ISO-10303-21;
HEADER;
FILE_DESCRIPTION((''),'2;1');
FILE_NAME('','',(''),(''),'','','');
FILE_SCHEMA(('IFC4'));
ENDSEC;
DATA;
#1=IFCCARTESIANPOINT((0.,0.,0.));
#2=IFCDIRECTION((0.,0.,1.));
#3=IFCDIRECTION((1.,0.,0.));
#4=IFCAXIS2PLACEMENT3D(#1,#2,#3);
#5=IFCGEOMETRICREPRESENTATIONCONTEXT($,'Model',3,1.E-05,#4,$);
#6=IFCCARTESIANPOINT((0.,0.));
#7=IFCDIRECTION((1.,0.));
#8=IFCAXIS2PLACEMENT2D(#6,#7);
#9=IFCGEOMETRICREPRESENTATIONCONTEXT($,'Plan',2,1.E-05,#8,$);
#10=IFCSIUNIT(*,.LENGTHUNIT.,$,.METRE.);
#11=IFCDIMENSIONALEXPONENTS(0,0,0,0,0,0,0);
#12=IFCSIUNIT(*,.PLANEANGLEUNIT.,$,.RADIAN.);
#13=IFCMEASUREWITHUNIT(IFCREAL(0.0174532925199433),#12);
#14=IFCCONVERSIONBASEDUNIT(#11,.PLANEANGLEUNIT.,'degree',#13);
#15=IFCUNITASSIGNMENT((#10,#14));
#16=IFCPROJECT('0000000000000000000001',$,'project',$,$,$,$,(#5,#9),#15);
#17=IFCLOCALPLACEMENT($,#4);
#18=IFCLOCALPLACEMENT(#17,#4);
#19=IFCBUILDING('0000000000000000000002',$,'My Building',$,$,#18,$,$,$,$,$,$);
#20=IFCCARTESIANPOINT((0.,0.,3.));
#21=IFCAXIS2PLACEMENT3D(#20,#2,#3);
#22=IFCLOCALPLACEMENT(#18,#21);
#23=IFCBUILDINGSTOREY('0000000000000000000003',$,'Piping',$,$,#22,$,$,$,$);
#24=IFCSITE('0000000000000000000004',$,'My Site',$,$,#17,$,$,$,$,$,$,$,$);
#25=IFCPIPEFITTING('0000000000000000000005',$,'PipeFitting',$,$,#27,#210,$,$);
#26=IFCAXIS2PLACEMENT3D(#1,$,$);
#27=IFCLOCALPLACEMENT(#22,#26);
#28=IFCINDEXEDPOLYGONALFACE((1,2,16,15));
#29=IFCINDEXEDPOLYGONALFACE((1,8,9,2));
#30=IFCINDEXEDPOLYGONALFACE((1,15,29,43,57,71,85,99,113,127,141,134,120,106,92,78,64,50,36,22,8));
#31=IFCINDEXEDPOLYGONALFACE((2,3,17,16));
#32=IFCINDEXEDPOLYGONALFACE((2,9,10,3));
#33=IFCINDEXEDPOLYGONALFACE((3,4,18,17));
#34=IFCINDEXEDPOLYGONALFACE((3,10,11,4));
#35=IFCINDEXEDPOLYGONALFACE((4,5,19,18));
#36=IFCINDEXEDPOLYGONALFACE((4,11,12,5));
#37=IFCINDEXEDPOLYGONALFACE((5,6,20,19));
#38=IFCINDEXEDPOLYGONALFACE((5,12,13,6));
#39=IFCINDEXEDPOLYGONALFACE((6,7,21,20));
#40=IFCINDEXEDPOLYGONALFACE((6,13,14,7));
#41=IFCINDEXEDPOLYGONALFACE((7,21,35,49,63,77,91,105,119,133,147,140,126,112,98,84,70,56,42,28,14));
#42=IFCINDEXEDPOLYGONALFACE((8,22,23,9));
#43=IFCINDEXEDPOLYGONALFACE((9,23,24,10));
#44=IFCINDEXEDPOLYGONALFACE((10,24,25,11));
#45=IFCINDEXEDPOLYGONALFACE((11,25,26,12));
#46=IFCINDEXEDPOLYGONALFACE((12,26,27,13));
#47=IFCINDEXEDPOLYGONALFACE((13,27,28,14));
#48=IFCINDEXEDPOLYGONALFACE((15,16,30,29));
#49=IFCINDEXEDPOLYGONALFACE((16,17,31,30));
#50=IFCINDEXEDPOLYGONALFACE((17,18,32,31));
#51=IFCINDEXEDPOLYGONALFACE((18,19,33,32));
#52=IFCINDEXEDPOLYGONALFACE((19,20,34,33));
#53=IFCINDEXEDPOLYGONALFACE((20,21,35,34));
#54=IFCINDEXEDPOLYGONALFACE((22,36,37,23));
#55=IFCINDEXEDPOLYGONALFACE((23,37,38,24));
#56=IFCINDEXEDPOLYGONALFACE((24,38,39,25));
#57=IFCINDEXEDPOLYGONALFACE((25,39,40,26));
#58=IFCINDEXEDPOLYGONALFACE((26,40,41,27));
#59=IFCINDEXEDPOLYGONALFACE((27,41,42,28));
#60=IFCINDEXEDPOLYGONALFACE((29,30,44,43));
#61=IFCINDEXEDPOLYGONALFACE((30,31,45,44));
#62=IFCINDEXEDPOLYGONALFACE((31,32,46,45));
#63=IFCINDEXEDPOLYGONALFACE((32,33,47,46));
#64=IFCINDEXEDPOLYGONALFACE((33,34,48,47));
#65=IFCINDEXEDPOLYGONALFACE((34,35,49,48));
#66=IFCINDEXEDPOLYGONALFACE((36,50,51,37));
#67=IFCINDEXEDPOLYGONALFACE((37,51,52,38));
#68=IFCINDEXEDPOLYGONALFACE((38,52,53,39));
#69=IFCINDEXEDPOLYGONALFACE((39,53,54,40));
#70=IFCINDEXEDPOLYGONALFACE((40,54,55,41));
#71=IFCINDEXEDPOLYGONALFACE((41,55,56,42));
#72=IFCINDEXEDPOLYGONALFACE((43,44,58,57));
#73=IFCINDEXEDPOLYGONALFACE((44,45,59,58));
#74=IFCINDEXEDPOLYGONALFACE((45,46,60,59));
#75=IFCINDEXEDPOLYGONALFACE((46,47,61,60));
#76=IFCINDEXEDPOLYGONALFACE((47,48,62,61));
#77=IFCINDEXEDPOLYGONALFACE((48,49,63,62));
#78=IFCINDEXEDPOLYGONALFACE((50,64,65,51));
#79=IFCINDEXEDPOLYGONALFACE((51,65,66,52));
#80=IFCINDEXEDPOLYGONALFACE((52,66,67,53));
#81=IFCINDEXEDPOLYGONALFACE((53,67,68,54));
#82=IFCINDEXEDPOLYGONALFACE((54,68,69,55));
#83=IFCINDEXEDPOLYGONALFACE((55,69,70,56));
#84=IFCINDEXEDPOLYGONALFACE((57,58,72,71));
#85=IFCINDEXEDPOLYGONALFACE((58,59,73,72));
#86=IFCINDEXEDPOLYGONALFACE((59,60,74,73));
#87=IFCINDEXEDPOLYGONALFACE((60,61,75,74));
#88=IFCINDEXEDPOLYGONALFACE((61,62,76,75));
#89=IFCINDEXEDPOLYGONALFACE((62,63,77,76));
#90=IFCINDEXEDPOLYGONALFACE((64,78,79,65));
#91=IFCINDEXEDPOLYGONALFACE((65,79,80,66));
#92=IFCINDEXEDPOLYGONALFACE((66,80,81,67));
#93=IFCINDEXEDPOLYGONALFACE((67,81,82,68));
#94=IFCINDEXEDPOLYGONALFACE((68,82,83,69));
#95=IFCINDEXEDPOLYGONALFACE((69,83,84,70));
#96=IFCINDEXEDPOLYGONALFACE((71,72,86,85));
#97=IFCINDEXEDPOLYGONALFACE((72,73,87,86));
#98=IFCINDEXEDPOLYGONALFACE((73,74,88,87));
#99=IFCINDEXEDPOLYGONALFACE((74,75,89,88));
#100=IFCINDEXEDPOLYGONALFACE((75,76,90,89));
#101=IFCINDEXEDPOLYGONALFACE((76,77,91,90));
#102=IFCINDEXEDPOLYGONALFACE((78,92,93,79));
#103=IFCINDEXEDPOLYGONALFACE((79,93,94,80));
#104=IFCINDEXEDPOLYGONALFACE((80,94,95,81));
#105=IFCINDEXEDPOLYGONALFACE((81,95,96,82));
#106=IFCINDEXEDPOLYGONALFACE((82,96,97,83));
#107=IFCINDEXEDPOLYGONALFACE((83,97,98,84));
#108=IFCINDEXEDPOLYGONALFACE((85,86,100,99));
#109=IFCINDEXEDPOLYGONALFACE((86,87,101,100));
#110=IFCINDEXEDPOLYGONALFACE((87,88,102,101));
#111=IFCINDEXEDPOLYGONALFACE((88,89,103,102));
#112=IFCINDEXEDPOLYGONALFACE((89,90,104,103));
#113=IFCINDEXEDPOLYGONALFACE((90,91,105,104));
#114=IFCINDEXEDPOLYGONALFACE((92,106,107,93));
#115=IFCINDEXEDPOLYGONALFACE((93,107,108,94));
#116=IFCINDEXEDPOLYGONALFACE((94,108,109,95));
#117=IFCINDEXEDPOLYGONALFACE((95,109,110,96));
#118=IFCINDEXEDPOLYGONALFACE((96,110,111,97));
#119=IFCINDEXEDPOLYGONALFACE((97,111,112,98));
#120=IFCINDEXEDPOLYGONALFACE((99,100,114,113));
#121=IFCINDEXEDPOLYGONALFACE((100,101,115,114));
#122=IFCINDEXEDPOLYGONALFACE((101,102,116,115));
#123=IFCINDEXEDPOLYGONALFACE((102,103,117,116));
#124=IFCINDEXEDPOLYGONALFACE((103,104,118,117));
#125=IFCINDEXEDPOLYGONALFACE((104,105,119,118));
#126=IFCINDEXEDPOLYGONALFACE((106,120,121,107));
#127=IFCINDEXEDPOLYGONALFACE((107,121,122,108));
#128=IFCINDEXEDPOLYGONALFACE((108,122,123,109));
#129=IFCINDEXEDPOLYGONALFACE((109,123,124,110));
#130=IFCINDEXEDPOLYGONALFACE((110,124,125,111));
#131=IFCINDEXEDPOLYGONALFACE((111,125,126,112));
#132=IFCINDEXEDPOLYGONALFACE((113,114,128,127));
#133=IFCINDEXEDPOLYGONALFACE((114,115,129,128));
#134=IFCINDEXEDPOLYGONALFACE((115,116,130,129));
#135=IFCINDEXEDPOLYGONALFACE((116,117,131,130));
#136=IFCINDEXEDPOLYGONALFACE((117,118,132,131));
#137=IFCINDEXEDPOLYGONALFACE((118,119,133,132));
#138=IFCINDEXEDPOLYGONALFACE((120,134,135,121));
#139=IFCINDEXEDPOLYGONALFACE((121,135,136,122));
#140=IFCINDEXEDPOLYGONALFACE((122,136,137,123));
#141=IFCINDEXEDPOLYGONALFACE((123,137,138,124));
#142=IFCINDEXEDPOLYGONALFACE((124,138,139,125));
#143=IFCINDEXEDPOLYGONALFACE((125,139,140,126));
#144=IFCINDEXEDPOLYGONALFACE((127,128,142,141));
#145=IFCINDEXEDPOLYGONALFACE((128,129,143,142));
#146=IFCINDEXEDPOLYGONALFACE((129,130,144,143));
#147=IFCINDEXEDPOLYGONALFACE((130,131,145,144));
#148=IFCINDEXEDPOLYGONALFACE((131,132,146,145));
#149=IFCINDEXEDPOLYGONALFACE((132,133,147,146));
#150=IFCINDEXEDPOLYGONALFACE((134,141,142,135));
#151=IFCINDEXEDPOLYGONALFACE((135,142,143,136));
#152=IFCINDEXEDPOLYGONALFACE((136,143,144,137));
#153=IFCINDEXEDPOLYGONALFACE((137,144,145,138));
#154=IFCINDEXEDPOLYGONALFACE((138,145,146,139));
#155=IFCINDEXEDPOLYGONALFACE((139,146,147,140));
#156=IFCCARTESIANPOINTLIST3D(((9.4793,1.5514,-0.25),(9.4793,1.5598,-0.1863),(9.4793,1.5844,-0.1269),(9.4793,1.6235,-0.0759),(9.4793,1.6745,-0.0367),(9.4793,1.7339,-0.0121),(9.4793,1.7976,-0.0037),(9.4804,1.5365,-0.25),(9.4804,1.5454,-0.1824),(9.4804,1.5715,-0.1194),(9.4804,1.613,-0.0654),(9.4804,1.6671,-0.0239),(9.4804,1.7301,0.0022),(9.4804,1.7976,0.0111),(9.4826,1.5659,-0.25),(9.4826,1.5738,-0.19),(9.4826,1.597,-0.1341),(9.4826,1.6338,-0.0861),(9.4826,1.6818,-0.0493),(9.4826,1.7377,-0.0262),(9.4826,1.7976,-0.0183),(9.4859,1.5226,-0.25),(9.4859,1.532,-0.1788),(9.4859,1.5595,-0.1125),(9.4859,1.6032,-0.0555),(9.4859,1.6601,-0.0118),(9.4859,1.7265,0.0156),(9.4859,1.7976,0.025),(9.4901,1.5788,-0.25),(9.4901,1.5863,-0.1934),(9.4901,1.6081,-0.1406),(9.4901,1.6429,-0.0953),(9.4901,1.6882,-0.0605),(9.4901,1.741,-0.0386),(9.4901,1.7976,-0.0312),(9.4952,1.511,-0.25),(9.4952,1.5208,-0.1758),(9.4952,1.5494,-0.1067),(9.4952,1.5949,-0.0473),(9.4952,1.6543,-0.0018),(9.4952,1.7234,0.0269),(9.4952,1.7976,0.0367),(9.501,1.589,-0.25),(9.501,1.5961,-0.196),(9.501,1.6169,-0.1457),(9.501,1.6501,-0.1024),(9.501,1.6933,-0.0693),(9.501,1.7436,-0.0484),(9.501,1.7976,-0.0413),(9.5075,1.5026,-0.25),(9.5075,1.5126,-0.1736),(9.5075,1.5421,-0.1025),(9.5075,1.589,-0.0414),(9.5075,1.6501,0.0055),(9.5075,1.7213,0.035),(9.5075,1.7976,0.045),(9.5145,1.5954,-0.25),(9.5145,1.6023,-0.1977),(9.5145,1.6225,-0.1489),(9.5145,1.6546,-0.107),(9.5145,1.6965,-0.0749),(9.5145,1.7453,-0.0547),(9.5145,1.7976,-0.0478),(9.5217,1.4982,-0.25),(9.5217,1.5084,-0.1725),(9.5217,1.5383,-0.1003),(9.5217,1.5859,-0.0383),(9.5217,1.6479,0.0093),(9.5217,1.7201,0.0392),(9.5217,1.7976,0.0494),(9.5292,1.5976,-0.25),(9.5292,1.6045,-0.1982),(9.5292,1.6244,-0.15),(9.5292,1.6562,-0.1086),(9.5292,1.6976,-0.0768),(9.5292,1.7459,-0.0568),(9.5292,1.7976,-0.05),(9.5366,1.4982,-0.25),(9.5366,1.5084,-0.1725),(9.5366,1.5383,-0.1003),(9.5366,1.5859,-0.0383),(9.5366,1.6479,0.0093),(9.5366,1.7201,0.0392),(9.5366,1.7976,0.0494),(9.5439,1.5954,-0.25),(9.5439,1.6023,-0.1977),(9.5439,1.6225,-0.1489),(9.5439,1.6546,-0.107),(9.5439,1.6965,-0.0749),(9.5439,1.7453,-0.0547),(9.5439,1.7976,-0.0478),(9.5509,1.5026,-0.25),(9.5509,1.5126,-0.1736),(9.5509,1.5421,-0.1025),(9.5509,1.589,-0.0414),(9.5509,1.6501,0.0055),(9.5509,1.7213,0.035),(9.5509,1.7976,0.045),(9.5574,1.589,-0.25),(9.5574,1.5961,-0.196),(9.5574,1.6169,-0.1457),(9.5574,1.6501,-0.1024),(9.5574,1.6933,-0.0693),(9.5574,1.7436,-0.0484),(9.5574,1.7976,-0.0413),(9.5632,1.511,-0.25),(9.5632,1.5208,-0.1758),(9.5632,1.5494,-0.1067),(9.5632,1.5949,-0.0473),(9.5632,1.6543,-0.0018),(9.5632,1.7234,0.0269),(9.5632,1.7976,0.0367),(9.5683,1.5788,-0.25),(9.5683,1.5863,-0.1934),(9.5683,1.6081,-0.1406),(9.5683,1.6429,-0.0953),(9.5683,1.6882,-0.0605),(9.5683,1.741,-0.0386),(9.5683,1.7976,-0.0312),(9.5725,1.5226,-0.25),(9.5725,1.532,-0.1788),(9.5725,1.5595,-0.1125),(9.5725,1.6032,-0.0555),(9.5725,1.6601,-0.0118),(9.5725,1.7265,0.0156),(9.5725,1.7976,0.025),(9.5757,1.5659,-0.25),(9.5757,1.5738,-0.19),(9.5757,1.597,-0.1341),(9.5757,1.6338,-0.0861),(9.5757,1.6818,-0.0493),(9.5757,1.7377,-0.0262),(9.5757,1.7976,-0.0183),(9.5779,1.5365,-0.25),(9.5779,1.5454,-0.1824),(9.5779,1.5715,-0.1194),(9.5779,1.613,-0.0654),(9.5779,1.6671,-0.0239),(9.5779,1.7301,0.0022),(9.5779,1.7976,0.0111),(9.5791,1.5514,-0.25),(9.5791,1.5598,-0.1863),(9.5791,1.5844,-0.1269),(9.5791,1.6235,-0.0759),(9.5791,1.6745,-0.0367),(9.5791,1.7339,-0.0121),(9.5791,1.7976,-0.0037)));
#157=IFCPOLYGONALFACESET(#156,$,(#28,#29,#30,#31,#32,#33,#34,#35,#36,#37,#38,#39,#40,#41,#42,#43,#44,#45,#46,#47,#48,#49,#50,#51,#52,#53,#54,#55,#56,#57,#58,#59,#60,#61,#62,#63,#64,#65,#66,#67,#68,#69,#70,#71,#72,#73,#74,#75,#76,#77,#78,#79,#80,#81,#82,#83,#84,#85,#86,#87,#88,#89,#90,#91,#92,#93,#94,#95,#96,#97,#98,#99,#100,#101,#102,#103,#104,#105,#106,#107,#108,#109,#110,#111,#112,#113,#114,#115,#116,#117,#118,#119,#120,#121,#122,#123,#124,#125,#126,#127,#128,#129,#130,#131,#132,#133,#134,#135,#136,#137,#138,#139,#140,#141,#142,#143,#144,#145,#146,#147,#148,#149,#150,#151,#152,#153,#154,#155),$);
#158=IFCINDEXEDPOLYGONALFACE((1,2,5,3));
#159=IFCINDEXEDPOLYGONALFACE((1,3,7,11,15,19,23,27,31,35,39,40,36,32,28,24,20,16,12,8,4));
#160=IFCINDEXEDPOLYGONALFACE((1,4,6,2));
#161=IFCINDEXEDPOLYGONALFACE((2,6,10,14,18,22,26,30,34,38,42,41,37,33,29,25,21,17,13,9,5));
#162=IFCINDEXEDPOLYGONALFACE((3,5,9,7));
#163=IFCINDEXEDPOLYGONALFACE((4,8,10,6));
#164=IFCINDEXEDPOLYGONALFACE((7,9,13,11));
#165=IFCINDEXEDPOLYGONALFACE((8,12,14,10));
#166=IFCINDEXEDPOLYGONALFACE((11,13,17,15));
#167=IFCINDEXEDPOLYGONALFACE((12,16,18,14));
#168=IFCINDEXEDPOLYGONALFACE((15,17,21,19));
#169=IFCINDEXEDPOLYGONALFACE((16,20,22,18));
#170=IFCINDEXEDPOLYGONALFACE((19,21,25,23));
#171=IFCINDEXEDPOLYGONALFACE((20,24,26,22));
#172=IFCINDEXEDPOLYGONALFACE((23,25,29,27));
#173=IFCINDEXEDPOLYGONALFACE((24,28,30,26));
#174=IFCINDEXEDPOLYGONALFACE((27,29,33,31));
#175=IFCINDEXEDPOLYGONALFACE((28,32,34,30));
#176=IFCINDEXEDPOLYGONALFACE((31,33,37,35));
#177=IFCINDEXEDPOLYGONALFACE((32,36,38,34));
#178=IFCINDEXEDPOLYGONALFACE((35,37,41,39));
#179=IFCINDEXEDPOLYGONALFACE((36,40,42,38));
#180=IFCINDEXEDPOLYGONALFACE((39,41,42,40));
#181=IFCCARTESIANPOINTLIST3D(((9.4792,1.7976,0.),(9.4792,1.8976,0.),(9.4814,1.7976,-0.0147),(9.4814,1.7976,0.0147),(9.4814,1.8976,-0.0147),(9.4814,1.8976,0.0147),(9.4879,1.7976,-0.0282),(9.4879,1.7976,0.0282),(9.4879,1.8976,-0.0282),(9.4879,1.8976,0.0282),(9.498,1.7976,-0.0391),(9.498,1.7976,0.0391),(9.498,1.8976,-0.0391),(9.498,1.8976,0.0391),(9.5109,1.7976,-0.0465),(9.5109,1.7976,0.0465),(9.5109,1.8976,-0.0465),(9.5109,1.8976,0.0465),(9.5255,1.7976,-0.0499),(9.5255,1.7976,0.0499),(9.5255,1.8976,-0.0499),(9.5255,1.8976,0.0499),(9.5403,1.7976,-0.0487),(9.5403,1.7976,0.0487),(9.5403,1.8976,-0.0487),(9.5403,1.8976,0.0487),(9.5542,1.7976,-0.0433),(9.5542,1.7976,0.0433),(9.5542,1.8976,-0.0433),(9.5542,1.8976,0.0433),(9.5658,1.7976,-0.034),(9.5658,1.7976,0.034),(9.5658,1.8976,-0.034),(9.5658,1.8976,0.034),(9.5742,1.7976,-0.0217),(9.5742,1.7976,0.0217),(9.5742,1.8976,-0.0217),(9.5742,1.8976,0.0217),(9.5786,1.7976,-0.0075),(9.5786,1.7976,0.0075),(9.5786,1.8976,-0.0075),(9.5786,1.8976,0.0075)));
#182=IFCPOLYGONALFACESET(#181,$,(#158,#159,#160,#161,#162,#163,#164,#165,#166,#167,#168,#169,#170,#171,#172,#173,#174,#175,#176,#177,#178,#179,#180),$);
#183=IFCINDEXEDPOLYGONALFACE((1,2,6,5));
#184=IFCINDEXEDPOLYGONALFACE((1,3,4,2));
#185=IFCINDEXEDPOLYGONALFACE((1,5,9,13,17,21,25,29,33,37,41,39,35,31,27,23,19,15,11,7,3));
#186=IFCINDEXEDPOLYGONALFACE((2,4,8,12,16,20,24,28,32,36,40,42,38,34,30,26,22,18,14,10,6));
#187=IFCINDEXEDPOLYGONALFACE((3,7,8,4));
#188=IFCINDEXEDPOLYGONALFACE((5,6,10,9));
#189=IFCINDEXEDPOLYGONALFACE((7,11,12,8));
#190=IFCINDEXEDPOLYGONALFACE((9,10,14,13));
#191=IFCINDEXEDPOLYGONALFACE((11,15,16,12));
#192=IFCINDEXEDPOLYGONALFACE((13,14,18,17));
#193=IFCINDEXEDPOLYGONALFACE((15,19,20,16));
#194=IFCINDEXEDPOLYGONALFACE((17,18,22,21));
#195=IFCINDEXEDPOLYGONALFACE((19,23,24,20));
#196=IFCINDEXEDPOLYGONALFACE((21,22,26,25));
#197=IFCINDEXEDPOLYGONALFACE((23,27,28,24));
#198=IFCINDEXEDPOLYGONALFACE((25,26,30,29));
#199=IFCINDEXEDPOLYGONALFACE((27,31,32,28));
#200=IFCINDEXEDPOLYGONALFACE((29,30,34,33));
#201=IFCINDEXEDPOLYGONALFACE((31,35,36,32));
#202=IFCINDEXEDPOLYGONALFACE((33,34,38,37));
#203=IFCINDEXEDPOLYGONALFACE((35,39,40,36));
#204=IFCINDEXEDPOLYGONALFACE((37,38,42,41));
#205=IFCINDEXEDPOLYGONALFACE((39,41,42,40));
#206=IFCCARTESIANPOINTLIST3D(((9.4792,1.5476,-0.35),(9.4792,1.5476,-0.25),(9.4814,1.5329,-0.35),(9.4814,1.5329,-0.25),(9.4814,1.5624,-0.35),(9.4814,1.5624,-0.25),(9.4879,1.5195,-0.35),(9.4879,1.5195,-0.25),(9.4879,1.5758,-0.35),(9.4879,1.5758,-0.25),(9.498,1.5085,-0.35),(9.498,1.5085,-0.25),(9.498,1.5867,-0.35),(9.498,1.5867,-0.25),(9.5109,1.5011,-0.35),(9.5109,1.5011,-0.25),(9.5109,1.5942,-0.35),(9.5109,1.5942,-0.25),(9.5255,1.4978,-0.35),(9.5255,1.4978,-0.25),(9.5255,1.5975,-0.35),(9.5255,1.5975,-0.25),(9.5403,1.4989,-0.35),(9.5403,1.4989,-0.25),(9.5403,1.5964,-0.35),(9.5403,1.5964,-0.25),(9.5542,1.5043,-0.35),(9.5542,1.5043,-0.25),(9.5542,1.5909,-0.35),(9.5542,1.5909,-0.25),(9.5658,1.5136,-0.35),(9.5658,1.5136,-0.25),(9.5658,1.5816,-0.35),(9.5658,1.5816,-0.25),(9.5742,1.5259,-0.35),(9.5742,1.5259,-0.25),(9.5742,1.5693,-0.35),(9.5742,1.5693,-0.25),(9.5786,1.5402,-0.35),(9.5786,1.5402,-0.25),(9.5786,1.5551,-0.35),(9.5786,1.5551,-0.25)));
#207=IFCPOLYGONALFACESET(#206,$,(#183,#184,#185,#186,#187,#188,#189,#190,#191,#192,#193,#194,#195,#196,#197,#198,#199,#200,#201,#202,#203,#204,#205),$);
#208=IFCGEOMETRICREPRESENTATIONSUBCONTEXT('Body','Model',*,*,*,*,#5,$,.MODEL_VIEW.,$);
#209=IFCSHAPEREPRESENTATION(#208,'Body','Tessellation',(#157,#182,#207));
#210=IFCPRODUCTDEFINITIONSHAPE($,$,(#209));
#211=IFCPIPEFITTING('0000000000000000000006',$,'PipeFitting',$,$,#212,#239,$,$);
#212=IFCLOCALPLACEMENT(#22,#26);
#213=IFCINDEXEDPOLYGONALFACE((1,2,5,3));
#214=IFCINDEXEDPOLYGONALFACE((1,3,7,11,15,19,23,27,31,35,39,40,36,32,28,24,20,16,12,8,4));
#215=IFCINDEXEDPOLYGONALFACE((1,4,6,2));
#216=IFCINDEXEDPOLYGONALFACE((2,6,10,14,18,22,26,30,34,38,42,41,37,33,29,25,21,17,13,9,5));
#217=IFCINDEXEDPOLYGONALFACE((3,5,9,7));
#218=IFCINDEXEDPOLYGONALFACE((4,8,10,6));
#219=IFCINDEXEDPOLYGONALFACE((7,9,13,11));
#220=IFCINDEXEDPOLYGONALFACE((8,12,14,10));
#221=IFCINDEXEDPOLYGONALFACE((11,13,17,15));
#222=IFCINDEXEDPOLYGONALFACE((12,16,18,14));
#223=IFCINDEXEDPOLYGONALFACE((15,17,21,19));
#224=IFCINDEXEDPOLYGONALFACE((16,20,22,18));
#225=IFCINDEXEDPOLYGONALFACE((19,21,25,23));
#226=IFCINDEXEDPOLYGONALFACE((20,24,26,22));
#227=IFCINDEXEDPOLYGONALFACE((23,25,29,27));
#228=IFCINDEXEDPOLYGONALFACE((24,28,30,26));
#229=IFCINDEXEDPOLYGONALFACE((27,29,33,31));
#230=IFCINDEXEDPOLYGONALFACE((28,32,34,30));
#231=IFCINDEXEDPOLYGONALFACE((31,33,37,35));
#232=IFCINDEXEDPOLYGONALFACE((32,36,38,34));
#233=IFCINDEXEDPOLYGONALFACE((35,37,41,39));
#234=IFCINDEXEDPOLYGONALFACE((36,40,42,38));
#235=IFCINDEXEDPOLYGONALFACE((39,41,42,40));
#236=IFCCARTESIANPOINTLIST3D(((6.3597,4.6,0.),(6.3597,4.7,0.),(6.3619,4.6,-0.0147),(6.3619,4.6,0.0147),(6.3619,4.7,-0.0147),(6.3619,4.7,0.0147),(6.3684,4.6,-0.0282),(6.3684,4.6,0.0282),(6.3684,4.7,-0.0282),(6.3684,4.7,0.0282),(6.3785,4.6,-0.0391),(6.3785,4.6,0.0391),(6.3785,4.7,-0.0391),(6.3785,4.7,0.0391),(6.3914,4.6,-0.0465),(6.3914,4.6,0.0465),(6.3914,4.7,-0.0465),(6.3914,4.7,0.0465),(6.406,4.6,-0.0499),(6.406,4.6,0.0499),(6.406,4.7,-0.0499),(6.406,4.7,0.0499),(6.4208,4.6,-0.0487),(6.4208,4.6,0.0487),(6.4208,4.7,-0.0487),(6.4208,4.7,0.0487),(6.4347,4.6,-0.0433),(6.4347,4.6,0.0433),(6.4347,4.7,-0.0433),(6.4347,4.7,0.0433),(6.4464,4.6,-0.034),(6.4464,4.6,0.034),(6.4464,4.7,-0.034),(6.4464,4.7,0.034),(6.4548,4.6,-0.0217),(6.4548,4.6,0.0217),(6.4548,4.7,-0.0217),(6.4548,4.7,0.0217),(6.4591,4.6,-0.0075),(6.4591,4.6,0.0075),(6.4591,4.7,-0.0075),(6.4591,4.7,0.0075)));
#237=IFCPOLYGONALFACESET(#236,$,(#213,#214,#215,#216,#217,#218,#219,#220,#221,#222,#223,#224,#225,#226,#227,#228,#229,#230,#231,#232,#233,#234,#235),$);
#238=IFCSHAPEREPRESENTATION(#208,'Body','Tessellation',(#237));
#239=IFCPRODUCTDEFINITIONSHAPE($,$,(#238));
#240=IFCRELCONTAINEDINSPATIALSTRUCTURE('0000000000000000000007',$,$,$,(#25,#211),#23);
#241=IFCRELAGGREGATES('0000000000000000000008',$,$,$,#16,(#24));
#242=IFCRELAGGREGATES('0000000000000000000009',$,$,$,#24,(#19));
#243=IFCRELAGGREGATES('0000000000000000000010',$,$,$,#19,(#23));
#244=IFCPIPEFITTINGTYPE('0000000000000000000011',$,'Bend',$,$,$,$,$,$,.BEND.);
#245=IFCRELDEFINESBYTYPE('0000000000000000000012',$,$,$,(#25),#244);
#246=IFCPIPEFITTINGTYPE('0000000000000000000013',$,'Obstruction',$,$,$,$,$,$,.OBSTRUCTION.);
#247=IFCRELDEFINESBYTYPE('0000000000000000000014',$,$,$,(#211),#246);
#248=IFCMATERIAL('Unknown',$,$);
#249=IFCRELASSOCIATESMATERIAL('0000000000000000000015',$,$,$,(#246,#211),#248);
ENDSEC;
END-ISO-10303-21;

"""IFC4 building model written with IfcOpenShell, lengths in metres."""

from ifc_helpers import new_model, entity, si_unit, converted_unit, frame, origin_with_axes, origin_2d_with_axis, place, context, subcontext, project, spatial, circle, extrude, source, transform, mapped, material, material_profile, profile_set, profile_usage, type_object, type_shapes, element, save


model = new_model("IFC4")

# Units and contexts
model_context = context("Model", 3, precision=1e-05, world=origin_with_axes())
plan_context = context("Plan", 2, precision=1e-05, world=origin_2d_with_axis())
body_context = subcontext(model_context, "Body", "Model", "MODEL_VIEW")
ifc_project = project(units=[si_unit("LENGTHUNIT", "METRE"), converted_unit("PLANEANGLEUNIT", "degree", entity("IfcReal", 0.0174532925199433), si_unit("PLANEANGLEUNIT", "RADIAN"), dimensions=[0, 0, 0, 0, 0, 0, 0])], contexts=[model_context, plan_context])

# Site, building, storey
site_placement = place(None, origin_with_axes())
site = spatial("IfcSite", under=ifc_project, at=site_placement, Name="My Site")
building_placement = place(site_placement, origin_with_axes())
building = spatial("IfcBuilding", under=site, at=building_placement, Name="My Building")
storey_placement = place(building_placement, frame((0.0, 0.0, 3.0), z_axis=(0.0, 0.0, 1.0), x_axis=(1.0, 0.0, 0.0)))
storey = spatial("IfcBuildingStorey", under=building, at=storey_placement, Name="Piping")

# Shared definitions
ifc_material = material(Name="Unknown")

# Shared definitions
pipe_fitting_type_1 = type_object("IfcPipeFittingType", Name="Bend", PredefinedType="BEND")
shared_shape = source(origin_with_axes(), body_context, "Body", "SolidModel", [
    entity("IfcSweptDiskSolid", entity("IfcIndexedPolyCurve", entity("IfcCartesianPointList3D", [[0.0, 0.0, -0.1], [0.0, -0.0732, -0.2768], [0.0, -0.25, -0.35]]), [entity("IfcArcIndex", [1, 2, 3])]), 0.05),
    extrude(circle(Radius=0.05), origin_with_axes(), (0.0, 0.0, -1.0), 0.1),
    extrude(circle(Radius=0.05), frame((0.0, -0.25, -0.35), z_axis=(0.0, -1.0, 0.0), x_axis=(1.0, 0.0, 0.0)), (0.0, 0.0, 1.0), 0.1),
])
type_shapes(pipe_fitting_type_1, [shared_shape])

# Pipe fittings
for number, where, z_axis, x_axis, name in (
    (1, (9.5292, 1.8976, 0.0), (0.0, 1.0, 0.0), (-1.0, 0.0, 0.0), "PipeFitting"),
):
    element("IfcPipeFitting", number, at=place(storey_placement, frame(where, z_axis=z_axis, x_axis=x_axis)), inside=storey, type_object=pipe_fitting_type_1, Name=name, context=body_context, shape_type="MappedRepresentation", body=[
        mapped(shared_shape, transform((0.0, 0.0, 0.0), x_axis=(1.0, 0.0, 0.0), y_axis=(0.0, 1.0, 0.0), z_axis=(0.0, 0.0, 1.0), scale=1.0)),
    ])
ifc_material_profile_1 = material_profile(ifc_material, circle(Radius=0.05))
ifc_profile_set_1 = profile_set([ifc_material_profile_1])
ifc_profile_usage_1 = profile_usage(ifc_profile_set_1, cardinal=5)
pipe_fitting_type_2 = type_object("IfcPipeFittingType", Name="Obstruction", PredefinedType="OBSTRUCTION", material=ifc_profile_set_1)
pipe_fitting_1_placement = place(storey_placement, frame((6.4097, 4.6, 0.0), z_axis=(0.0, 1.0, 0.0), x_axis=(-1.0, 0.0, 0.0)))
element("IfcPipeFitting", 2, at=pipe_fitting_1_placement, inside=storey, type_object=pipe_fitting_type_2, material=ifc_profile_usage_1, Name="PipeFitting", context=body_context, shape_type="SweptSolid", body=[
    extrude(circle(Radius=0.05), origin_with_axes(), (0.0, 0.0, 1.0), 0.1),
])

save(model, "model.ifc")
